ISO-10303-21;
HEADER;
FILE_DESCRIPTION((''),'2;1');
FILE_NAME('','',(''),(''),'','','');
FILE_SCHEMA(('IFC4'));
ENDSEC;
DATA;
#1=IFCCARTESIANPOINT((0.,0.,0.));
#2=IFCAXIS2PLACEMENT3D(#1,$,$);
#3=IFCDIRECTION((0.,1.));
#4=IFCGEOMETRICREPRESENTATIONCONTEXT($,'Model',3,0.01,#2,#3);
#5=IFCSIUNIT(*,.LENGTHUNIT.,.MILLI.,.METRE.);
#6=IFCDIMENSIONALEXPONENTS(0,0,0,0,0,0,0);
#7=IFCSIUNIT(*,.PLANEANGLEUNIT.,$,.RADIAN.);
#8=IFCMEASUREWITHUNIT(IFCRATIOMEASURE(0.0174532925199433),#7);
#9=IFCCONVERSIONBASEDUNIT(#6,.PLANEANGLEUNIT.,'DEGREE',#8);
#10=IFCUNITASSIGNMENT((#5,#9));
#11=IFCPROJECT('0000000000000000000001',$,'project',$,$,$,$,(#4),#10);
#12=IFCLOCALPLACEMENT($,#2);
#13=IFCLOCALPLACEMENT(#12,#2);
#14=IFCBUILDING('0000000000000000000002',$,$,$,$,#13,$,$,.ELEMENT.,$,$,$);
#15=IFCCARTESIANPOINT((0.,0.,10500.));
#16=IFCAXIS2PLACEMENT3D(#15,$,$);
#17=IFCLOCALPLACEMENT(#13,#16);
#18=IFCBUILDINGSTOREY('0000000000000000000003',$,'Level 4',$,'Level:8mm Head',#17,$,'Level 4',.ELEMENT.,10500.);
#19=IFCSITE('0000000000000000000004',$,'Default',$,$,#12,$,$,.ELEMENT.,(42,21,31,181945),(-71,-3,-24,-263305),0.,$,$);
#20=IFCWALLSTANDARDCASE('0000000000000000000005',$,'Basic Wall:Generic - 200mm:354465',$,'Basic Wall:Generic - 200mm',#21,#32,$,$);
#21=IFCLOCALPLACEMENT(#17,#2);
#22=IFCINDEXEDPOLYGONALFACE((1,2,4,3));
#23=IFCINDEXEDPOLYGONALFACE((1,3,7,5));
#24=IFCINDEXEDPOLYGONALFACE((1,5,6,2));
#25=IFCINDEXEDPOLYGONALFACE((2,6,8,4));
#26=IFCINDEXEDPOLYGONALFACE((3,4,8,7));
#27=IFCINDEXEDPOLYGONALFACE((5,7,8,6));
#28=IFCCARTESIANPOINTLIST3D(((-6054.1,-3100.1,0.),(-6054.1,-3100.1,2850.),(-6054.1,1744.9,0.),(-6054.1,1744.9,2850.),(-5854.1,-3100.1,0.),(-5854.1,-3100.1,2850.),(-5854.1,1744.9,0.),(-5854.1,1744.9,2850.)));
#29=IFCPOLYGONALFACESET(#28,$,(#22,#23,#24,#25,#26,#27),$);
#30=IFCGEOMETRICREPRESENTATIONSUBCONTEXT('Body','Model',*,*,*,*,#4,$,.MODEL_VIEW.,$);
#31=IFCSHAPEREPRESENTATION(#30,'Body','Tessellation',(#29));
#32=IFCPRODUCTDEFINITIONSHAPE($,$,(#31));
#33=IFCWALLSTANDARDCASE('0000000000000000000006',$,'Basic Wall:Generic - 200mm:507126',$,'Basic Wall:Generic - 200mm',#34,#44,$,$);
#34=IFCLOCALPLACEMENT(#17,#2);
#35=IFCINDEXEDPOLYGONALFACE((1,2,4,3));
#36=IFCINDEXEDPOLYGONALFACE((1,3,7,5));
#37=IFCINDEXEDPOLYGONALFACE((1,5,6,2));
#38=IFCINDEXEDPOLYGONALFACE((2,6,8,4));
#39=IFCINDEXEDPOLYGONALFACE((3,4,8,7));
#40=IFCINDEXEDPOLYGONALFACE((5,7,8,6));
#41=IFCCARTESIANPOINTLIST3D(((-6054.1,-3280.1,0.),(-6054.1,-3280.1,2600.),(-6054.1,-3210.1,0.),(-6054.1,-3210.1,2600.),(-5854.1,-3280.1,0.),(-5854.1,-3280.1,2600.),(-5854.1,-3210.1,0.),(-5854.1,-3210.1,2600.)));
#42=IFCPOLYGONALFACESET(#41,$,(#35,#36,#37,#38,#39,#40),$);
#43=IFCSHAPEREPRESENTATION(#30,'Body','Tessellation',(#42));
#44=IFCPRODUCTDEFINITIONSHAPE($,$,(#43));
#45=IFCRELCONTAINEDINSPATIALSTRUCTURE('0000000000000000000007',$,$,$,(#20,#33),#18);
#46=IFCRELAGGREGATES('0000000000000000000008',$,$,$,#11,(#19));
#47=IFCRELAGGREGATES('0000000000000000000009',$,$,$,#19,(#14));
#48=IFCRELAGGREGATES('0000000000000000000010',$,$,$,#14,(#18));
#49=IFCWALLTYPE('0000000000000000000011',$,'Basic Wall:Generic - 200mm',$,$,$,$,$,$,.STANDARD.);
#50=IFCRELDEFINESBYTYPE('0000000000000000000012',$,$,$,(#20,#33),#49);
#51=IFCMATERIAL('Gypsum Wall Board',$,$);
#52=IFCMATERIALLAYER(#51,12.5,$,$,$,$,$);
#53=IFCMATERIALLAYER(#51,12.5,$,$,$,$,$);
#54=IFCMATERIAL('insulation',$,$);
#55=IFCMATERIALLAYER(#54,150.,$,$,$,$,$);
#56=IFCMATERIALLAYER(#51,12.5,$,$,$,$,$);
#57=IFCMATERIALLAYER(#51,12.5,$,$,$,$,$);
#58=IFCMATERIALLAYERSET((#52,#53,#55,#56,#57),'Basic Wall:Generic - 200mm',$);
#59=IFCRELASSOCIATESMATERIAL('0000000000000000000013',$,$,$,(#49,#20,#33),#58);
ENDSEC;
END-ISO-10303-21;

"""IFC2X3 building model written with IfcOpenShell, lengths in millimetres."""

from ifc_helpers import new_model, entity, si_unit, converted_unit, direction, frame, frame_2d, origin, place, context, subcontext, project, spatial, rectangle, extrude, material, layer, layer_set, layer_usage, type_object, element, save


model = new_model("IFC2X3")

# Units and contexts
model_context = context("Model", 3, precision=0.01, world=origin(), true_north=direction((0.0, 1.0)))
body_context = subcontext(model_context, "Body", "Model", "MODEL_VIEW")
ifc_project = project(units=[si_unit("LENGTHUNIT", "METRE", prefix="MILLI"), converted_unit("PLANEANGLEUNIT", "DEGREE", entity("IfcRatioMeasure", 0.0174532925199433), si_unit("PLANEANGLEUNIT", "RADIAN"), dimensions=[0, 0, 0, 0, 0, 0, 0])], contexts=[model_context])

# Site, building, storey
site_placement = place(None, frame((0.0, 0.0, 0.0)))
site = spatial("IfcSite", under=ifc_project, at=site_placement, Name="Default", CompositionType="ELEMENT", RefLatitude=(42, 21, 31, 181945), RefLongitude=(-71, -3, -24, -263305), RefElevation=0.0)
building_placement = place(site_placement, origin())
building = spatial("IfcBuilding", under=site, at=building_placement, CompositionType="ELEMENT")
storey_placement = place(building_placement, frame((0.0, 0.0, 10500.0)))
storey = spatial("IfcBuildingStorey", under=building, at=storey_placement, Name="Level 4", ObjectType="Level:8mm Head", LongName="Level 4", CompositionType="ELEMENT", Elevation=10500.0)

# Walls
ifc_material_1 = material(Name="Gypsum Wall Board")
ifc_layer_1 = layer(ifc_material_1, 12.5)
ifc_layer_2 = layer(ifc_material_1, 12.5)
ifc_material_2 = material(Name="insulation")
ifc_layer_3 = layer(ifc_material_2, 150.0)
ifc_layer_4 = layer(ifc_material_1, 12.5)
ifc_layer_5 = layer(ifc_material_1, 12.5)
ifc_layer_set = layer_set([ifc_layer_1, ifc_layer_2, ifc_layer_3, ifc_layer_4, ifc_layer_5], Name="Basic Wall:Generic - 200mm")
ifc_layer_usage_1 = layer_usage(ifc_layer_set, "AXIS2", "NEGATIVE", 100.0)
wall_type = type_object("IfcWallType", Name="Basic Wall:Generic - 200mm", PredefinedType="STANDARD", material=ifc_layer_set)
wall_1_placement = place(storey_placement, frame((-5954.1, -3100.1, 0.0), z_axis=(0.0, 0.0, 1.0), x_axis=(0.0, 1.0, 0.0)))
element("IfcWallStandardCase", 1, at=wall_1_placement, inside=storey, type_object=wall_type, material=ifc_layer_usage_1, Name="Basic Wall:Generic - 200mm:354465", ObjectType="Basic Wall:Generic - 200mm", context=body_context, shape_type="SweptSolid", body=[
    extrude(rectangle(XDim=4845.0, YDim=200.0, at=frame_2d((2422.5, 0.0), x_axis=(-1.0, 0.0))), origin(), (0.0, 0.0, 1.0), 2850.0),
])
ifc_layer_usage_2 = layer_usage(ifc_layer_set, "AXIS2", "NEGATIVE", 100.0)
wall_2_placement = place(storey_placement, frame((-5954.1, -3280.1, 0.0), z_axis=(0.0, 0.0, 1.0), x_axis=(0.0, 1.0, 0.0)))
element("IfcWallStandardCase", 2, at=wall_2_placement, inside=storey, type_object=wall_type, material=ifc_layer_usage_2, Name="Basic Wall:Generic - 200mm:507126", ObjectType="Basic Wall:Generic - 200mm", context=body_context, shape_type="SweptSolid", body=[
    extrude(rectangle(XDim=70.0, YDim=200.0, at=frame_2d((35.0, 0.0), x_axis=(-1.0, 0.0))), origin(), (0.0, 0.0, 1.0), 2600.0),
])

save(model, "model.ifc")
